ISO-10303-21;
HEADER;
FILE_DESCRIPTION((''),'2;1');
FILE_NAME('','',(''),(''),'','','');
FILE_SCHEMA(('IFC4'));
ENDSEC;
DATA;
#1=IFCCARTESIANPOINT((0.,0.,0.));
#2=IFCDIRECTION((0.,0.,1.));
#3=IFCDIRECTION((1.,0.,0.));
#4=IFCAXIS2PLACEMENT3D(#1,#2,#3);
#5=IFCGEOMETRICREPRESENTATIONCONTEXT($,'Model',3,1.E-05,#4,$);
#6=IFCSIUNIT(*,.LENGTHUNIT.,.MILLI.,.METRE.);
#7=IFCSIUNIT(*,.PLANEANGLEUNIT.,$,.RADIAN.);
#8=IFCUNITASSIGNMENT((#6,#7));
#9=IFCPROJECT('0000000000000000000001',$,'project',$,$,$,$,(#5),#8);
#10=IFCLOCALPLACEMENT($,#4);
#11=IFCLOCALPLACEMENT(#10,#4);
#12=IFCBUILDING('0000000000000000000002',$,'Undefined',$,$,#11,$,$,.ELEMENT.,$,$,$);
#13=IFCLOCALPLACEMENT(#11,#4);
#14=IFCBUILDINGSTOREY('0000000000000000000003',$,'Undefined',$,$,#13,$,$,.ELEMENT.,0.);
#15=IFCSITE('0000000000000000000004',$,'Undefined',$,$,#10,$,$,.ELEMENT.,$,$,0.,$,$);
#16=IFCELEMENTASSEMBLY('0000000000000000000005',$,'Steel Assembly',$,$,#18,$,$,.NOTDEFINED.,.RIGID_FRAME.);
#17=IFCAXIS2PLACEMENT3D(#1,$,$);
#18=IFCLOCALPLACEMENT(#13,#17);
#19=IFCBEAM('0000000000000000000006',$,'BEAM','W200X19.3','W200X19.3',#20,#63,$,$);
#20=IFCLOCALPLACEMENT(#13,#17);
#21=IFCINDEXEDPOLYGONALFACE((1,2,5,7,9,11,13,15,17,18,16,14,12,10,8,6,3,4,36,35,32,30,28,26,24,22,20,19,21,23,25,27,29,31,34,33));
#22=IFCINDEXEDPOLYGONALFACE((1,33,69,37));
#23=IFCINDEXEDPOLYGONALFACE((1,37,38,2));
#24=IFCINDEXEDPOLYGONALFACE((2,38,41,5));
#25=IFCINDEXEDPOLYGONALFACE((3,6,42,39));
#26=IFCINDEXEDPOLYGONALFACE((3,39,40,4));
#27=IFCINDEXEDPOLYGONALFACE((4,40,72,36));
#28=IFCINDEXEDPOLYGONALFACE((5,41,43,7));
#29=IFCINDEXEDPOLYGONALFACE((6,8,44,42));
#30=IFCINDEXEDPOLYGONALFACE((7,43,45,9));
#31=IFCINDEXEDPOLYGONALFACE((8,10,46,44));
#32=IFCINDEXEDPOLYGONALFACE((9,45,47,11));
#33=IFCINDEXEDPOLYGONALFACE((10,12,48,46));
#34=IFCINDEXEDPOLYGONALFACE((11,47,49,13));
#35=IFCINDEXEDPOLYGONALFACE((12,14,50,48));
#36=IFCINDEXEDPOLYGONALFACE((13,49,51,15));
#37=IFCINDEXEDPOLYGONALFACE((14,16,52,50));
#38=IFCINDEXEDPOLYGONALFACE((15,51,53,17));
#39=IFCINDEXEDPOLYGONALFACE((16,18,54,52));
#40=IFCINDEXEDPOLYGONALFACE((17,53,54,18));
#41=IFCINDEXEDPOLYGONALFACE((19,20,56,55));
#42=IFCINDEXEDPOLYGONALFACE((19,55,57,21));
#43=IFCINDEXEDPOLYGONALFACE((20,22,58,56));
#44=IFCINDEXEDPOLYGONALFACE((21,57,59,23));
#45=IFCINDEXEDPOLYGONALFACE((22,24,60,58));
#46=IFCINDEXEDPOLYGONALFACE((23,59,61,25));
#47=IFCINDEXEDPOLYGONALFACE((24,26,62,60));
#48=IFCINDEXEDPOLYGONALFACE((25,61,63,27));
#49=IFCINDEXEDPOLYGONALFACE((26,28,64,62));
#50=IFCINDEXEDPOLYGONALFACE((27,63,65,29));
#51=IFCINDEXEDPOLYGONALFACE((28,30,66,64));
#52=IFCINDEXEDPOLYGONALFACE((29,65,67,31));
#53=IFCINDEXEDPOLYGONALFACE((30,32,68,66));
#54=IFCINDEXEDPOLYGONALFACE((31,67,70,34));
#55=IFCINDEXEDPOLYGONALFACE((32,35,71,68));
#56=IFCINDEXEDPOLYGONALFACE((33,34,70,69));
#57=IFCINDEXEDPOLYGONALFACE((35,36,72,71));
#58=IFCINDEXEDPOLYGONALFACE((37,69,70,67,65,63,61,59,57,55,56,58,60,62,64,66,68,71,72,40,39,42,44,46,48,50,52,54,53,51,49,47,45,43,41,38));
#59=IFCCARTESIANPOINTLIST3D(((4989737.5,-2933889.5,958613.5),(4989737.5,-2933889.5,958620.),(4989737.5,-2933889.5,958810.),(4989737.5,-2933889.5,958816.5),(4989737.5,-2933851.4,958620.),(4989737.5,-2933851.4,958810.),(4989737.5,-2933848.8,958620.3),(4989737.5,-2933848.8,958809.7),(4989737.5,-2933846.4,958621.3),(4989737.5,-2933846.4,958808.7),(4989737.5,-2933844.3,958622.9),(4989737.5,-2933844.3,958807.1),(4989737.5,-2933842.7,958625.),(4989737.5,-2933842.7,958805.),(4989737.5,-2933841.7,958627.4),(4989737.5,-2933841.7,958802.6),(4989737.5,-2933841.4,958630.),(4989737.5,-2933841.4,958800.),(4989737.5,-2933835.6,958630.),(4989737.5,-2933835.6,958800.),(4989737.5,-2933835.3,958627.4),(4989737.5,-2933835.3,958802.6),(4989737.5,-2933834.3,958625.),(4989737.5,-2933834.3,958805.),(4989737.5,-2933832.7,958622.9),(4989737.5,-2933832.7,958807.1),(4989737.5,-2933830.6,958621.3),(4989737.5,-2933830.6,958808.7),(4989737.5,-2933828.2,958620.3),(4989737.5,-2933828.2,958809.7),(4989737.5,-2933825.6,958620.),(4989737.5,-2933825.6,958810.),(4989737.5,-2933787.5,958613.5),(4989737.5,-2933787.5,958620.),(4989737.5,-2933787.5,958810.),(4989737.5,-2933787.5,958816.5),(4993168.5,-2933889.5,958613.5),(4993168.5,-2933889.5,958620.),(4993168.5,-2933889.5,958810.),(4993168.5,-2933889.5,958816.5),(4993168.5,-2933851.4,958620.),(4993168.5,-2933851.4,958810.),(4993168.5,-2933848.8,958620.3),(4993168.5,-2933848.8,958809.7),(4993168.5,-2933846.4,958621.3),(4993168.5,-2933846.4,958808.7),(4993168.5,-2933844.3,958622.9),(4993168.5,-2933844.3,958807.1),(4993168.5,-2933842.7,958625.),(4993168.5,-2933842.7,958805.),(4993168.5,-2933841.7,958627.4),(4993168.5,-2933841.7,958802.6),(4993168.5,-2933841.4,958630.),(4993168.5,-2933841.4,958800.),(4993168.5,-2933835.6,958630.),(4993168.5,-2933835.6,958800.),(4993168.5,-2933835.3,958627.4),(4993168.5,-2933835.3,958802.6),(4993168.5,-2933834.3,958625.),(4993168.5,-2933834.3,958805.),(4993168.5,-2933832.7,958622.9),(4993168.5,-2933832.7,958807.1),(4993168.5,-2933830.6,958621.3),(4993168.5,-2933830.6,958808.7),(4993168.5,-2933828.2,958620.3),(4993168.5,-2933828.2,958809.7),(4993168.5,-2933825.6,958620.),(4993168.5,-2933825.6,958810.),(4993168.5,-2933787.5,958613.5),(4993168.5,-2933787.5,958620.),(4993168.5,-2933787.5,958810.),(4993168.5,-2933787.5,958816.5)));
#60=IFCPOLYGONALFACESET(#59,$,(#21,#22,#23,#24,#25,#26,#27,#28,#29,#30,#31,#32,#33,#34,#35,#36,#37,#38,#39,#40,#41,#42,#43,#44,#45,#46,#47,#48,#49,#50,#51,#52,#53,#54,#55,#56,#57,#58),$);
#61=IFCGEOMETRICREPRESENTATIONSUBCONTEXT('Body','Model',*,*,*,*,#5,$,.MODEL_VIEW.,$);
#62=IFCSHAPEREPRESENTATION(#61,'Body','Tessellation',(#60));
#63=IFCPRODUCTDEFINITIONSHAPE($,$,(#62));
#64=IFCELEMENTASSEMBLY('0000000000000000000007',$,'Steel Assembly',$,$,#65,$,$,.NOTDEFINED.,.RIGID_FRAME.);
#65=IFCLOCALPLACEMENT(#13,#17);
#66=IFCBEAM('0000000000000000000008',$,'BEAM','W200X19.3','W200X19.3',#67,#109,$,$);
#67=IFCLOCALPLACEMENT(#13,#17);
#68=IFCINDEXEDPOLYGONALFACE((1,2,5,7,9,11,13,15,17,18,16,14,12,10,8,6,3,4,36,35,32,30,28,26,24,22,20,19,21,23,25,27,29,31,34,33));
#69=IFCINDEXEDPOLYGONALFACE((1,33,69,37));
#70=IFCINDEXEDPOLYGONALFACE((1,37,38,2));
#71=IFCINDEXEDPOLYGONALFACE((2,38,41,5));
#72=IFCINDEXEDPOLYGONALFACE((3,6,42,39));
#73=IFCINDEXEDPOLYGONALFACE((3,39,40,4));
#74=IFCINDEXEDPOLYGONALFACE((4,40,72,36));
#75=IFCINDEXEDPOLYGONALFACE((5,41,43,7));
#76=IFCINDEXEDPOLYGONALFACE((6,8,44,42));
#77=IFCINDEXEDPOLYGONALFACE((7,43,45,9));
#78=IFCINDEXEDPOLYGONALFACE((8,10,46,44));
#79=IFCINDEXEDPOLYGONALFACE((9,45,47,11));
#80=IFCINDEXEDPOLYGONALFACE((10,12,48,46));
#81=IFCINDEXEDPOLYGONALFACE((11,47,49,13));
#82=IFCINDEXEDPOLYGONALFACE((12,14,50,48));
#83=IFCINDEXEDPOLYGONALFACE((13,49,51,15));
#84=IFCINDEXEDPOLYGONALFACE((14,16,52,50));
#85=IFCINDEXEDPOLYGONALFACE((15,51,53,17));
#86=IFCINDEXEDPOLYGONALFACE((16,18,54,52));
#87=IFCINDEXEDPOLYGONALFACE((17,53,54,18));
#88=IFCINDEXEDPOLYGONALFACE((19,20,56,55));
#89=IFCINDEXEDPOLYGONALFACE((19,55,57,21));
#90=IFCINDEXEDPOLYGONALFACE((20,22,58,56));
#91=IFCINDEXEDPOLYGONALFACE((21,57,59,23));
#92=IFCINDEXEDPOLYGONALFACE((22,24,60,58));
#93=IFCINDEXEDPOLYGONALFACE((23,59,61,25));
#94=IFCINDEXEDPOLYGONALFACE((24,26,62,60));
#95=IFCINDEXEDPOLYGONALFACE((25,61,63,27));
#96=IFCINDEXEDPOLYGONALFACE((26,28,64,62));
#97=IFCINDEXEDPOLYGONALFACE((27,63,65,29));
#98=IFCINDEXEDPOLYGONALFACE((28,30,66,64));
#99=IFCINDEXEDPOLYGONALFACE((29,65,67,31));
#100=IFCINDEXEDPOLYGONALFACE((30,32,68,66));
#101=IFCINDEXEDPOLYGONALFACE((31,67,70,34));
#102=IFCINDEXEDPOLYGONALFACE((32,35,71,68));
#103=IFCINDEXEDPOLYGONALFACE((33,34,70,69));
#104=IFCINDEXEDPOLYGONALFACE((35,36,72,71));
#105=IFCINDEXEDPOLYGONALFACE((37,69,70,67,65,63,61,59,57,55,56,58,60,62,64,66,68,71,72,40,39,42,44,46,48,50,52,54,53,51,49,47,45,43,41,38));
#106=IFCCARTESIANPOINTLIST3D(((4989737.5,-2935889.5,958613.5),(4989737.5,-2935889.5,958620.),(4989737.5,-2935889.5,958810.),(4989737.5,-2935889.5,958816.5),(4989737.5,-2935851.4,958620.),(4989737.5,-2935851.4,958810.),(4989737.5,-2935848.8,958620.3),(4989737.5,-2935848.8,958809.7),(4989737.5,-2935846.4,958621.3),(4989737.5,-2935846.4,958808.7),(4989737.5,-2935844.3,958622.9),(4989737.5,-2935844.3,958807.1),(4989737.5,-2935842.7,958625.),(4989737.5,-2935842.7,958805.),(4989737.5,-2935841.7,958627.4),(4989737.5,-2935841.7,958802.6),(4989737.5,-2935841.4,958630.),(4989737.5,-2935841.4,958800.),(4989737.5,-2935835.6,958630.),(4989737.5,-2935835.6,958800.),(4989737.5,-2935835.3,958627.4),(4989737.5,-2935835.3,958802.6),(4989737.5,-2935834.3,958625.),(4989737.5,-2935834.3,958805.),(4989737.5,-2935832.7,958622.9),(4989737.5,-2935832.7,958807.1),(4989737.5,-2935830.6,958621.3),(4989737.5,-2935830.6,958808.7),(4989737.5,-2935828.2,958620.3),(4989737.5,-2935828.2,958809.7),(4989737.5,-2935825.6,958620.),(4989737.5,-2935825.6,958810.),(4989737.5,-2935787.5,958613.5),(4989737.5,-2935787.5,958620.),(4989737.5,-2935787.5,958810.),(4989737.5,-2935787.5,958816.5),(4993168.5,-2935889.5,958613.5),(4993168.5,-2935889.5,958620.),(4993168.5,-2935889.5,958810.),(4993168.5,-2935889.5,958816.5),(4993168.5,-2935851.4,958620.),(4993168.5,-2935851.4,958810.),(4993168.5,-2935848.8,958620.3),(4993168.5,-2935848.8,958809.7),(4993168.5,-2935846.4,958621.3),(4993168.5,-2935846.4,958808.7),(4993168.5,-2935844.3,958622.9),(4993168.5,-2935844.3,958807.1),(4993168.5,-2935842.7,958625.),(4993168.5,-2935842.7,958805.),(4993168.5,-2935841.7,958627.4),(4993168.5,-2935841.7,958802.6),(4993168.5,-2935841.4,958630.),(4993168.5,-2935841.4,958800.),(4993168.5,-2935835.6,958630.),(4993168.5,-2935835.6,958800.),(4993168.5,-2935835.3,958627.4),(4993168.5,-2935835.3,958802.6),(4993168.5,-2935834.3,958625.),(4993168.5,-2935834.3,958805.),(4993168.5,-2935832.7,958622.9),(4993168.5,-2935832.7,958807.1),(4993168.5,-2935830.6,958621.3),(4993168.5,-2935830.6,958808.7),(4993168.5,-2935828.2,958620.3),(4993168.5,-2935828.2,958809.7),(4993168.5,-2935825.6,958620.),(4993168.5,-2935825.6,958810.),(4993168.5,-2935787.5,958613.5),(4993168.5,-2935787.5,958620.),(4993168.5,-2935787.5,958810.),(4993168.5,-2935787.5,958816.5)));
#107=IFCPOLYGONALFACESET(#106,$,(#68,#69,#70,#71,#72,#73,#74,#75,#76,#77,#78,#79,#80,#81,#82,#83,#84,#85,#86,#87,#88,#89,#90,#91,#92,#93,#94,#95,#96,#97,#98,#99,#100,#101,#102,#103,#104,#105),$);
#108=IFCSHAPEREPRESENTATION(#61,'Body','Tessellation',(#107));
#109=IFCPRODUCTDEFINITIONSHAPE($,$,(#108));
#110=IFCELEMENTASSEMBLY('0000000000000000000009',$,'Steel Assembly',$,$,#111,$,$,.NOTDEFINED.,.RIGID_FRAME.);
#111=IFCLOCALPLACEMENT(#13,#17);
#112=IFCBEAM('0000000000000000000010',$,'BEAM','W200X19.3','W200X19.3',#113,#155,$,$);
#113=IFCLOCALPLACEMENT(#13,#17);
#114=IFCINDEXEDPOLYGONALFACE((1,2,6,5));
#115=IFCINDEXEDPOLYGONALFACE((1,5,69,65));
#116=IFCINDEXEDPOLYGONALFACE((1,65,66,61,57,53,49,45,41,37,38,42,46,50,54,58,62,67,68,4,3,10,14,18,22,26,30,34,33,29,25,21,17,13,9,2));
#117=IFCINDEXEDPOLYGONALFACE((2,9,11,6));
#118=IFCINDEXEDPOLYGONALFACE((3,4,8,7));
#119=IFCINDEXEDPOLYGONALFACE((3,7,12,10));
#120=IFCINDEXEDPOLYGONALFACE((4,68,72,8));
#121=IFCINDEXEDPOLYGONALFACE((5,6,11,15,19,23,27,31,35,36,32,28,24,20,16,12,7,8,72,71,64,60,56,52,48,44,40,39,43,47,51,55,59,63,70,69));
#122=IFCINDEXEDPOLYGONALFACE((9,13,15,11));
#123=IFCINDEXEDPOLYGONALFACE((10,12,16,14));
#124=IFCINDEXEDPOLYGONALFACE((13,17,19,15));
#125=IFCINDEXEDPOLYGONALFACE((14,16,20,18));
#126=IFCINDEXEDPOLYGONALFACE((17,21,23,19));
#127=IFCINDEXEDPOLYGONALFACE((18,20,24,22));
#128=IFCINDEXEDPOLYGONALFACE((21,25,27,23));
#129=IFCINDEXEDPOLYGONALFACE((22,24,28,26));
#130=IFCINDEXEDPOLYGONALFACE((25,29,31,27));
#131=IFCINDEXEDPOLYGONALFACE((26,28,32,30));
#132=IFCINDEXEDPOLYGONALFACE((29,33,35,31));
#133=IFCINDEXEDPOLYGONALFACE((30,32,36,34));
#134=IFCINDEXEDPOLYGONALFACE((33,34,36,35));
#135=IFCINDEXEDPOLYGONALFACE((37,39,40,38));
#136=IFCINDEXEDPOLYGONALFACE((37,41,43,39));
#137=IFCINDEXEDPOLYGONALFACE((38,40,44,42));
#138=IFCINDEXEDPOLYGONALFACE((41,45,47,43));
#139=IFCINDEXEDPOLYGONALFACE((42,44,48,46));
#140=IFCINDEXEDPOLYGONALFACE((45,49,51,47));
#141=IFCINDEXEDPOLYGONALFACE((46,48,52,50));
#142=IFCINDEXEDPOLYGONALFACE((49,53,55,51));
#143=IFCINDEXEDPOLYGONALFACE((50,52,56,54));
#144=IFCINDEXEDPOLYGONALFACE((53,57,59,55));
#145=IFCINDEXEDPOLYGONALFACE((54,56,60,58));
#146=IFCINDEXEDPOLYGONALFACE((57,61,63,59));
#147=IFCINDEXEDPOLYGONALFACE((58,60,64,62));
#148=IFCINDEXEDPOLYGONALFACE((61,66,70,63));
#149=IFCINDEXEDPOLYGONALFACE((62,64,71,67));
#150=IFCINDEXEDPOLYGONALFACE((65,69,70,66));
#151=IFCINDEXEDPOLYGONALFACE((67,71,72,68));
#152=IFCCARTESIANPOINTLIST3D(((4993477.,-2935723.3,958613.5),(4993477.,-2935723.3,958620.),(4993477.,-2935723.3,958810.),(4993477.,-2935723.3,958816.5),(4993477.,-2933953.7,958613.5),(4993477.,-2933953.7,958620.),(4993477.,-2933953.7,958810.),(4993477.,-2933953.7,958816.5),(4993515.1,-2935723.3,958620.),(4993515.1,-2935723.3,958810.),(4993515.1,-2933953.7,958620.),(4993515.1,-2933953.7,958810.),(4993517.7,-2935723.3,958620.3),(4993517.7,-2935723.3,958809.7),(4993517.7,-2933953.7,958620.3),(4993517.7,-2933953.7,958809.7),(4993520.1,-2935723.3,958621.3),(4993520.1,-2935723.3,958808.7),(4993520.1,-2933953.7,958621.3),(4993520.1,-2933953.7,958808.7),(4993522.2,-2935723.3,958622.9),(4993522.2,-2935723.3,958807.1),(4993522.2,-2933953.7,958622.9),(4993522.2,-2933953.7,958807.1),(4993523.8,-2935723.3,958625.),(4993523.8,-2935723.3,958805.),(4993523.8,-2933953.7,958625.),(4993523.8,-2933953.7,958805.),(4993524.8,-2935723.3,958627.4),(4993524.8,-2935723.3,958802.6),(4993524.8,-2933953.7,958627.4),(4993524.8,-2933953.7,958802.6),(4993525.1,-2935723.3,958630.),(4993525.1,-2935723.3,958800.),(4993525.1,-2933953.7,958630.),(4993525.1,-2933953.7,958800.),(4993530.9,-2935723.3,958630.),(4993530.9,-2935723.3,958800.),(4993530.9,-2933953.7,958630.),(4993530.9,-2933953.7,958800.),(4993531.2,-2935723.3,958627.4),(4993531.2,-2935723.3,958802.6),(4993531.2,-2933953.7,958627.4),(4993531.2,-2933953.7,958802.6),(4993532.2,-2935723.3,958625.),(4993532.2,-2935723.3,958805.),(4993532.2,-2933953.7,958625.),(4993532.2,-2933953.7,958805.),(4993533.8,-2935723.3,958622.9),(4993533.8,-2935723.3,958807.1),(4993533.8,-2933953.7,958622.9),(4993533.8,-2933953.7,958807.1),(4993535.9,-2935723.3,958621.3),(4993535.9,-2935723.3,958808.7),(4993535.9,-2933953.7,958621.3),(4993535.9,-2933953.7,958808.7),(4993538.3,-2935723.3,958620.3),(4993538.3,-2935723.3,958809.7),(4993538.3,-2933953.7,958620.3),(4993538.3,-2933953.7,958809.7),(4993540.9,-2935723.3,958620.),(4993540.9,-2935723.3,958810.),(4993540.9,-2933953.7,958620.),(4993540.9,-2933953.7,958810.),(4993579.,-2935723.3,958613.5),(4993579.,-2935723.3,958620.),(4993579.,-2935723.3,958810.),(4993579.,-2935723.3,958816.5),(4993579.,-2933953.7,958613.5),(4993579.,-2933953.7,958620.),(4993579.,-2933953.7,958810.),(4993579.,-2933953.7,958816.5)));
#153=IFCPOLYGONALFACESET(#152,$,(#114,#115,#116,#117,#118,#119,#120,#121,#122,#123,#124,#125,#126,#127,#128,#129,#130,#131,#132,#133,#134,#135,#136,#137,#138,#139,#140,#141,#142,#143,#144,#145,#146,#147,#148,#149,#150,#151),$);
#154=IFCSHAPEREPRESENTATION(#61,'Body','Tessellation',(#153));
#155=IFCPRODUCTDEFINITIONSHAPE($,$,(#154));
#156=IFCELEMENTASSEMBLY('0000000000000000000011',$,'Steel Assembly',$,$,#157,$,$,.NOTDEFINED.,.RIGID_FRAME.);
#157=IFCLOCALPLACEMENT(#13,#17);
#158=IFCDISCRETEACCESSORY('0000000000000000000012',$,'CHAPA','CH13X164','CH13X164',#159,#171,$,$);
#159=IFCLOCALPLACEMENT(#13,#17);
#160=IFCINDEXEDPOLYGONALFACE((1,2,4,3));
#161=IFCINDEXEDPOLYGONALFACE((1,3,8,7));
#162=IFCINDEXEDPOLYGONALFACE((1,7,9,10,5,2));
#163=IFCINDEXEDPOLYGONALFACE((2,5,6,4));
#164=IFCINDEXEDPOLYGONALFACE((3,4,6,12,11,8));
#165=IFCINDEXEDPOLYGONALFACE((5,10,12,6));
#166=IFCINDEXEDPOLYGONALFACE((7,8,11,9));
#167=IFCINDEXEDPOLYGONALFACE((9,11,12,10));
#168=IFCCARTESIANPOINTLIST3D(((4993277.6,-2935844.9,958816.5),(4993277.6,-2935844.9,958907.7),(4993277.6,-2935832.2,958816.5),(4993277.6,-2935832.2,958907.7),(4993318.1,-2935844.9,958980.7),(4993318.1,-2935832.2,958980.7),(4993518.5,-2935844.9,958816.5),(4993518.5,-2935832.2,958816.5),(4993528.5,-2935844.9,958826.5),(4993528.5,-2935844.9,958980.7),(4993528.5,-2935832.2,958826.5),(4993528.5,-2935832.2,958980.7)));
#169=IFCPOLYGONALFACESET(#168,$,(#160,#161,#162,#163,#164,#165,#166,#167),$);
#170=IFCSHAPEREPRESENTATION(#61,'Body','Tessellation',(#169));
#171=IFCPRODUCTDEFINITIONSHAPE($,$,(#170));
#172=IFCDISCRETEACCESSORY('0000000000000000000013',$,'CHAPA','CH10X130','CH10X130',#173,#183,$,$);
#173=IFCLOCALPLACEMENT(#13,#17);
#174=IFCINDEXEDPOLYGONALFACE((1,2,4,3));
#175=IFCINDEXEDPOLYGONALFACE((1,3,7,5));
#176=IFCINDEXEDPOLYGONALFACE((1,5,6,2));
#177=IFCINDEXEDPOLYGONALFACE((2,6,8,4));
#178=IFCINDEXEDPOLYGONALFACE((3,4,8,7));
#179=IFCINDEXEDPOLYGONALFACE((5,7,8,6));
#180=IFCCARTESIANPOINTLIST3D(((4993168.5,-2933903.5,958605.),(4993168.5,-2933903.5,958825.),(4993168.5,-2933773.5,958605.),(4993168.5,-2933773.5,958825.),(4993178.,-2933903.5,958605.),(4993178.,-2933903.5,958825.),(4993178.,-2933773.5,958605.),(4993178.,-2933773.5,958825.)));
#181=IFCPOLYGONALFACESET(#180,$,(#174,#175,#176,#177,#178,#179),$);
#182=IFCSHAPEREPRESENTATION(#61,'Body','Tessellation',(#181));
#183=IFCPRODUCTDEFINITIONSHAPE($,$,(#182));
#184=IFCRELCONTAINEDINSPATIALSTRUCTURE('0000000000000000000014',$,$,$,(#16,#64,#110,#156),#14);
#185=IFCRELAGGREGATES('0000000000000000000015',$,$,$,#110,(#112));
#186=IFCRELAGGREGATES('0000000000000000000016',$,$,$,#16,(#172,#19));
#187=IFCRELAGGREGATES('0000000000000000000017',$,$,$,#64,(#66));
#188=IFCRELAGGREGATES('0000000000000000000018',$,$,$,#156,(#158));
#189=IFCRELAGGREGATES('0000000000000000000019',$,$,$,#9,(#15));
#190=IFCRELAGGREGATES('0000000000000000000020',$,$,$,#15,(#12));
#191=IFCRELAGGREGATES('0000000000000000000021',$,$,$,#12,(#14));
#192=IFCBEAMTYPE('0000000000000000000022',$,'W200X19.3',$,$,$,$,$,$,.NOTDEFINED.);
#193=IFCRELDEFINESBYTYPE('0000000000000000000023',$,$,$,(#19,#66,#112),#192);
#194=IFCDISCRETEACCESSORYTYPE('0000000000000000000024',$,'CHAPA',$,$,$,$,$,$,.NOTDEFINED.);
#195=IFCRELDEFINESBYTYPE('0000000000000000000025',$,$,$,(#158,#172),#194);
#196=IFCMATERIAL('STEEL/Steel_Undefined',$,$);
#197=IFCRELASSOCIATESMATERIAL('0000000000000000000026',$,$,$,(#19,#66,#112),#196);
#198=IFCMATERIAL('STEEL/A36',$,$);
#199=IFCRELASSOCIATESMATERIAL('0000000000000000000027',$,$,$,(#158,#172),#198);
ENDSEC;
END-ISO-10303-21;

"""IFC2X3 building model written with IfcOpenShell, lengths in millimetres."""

from ifc_helpers import new_model, si_unit, frame, origin_with_axes, origin_2d_with_axis, place, context, subcontext, project, spatial, polyline, i_section, outline, extrude, clip, halfspace, material, type_object, element, aggregate, save


model = new_model("IFC2X3")

# Units and contexts
model_context = context("Model", 3, precision=1e-05, world=origin_with_axes())
body_context = subcontext(model_context, "Body", "Model", "MODEL_VIEW")
ifc_project = project(units=[si_unit("LENGTHUNIT", "METRE", prefix="MILLI"), si_unit("PLANEANGLEUNIT", "RADIAN")], contexts=[model_context])

# Site, building, storey
site_placement = place(None, origin_with_axes())
site = spatial("IfcSite", under=ifc_project, at=site_placement, Name="Undefined", CompositionType="ELEMENT", RefElevation=0.0)
building_placement = place(site_placement, origin_with_axes())
building = spatial("IfcBuilding", under=site, at=building_placement, Name="Undefined", CompositionType="ELEMENT")
storey_placement = place(building_placement, origin_with_axes())
storey = spatial("IfcBuildingStorey", under=building, at=storey_placement, Name="Undefined", CompositionType="ELEMENT", Elevation=0.0)

# Element assemblies, beams
assembly_1_placement = place(storey_placement, origin_with_axes())
assembly_1 = element("IfcElementAssembly", 1, at=assembly_1_placement, inside=storey, Name="Steel Assembly", AssemblyPlace="NOTDEFINED", PredefinedType="RIGID_FRAME")
ifc_material_1 = material(Name="STEEL/Steel_Undefined")
beam_type = type_object("IfcBeamType", Name="W200X19.3", PredefinedType="NOTDEFINED")
beam_1_placement = place(assembly_1_placement, frame((4993179.0, -2933838.5, 958715.0), z_axis=(0.0, 0.0, -1.0), x_axis=(-1.0, 0.0, 0.0)))
beam_1 = element("IfcBeam", 2, at=beam_1_placement, type_object=beam_type, material=ifc_material_1, Name="BEAM", Description="W200X19.3", ObjectType="W200X19.3", context=body_context, shape_type="Clipping", body=[
    clip(clip(extrude(i_section(OverallWidth=102.0, OverallDepth=203.0, WebThickness=5.8, FlangeThickness=6.5, FilletRadius=10.0, at=origin_2d_with_axis()), frame((3441.5, 0.0, 0.0), z_axis=(-1.0, 0.0, 0.0), x_axis=(0.0, -1.0, 0.0)), (0.0, 0.0, 1.0), 3431.0), halfspace(frame((3441.5, 0.0, -101.5), z_axis=(-1.0, 0.0, 0.0), x_axis=(0.0, 1.0, 0.0)), True)), halfspace(frame((10.5, 0.0, -101.5), z_axis=(1.0, 0.0, 0.0), x_axis=(0.0, -1.0, 0.0)), True)),
])
assembly_2_placement = place(storey_placement, origin_with_axes())
assembly_2 = element("IfcElementAssembly", 3, at=assembly_2_placement, inside=storey, Name="Steel Assembly", AssemblyPlace="NOTDEFINED", PredefinedType="RIGID_FRAME")
beam_2_placement = place(assembly_2_placement, frame((4993179.0, -2935838.5, 958715.0), z_axis=(0.0, 0.0, -1.0), x_axis=(-1.0, 0.0, 0.0)))
beam_2 = element("IfcBeam", 4, at=beam_2_placement, type_object=beam_type, material=ifc_material_1, Name="BEAM", Description="W200X19.3", ObjectType="W200X19.3", context=body_context, shape_type="Clipping", body=[
    clip(clip(extrude(i_section(OverallWidth=102.0, OverallDepth=203.0, WebThickness=5.8, FlangeThickness=6.5, FilletRadius=10.0, at=origin_2d_with_axis()), frame((3441.5, 0.0, 0.0), z_axis=(-1.0, 0.0, 0.0), x_axis=(0.0, -1.0, 0.0)), (0.0, 0.0, 1.0), 3431.0), halfspace(frame((3441.5, 0.0, -101.5), z_axis=(-1.0, 0.0, 0.0), x_axis=(0.0, 1.0, 0.0)), True)), halfspace(frame((10.5, 0.0, -101.5), z_axis=(1.0, 0.0, 0.0), x_axis=(0.0, -1.0, 0.0)), True)),
])
assembly_3_placement = place(storey_placement, origin_with_axes())
assembly_3 = element("IfcElementAssembly", 5, at=assembly_3_placement, inside=storey, Name="Steel Assembly", AssemblyPlace="NOTDEFINED", PredefinedType="RIGID_FRAME")
beam_3_placement = place(assembly_3_placement, frame((4993528.0, -2933838.5, 958715.0), z_axis=(0.0, 0.0, -1.0), x_axis=(0.0, -1.0, 0.0)))
beam_3 = element("IfcBeam", 6, at=beam_3_placement, type_object=beam_type, material=ifc_material_1, Name="BEAM", Description="W200X19.3", ObjectType="W200X19.3", context=body_context, shape_type="Clipping", body=[
    clip(clip(clip(clip(extrude(i_section(OverallWidth=102.0, OverallDepth=203.0, WebThickness=5.8, FlangeThickness=6.5, FilletRadius=10.0, at=origin_2d_with_axis()), frame((1884.8, 0.0, 0.0), z_axis=(-1.0, 0.0, 0.0), x_axis=(0.0, -1.0, 0.0)), (0.0, 0.0, 1.0), 1769.6), halfspace(frame((1886.8, 51.0, 103.0), z_axis=(1.0, 0.0, 0.0), x_axis=(0.0, 0.0, -1.0)), False)), halfspace(frame((113.2, -51.0, 100.0), z_axis=(-1.0, 0.0, 0.0), x_axis=(0.0, 0.0, -1.0)), False)), halfspace(frame((1884.8, 0.0, 101.5), z_axis=(-1.0, 0.0, 0.0), x_axis=(0.0, -1.0, 0.0)), True)), halfspace(frame((115.2, 0.0, 101.5), z_axis=(1.0, 0.0, 0.0), x_axis=(0.0, 1.0, 0.0)), True)),
])
aggregate(assembly_3, [beam_3])

# Element assembly, discrete accessory
assembly_4_placement = place(storey_placement, origin_with_axes())
assembly_4 = element("IfcElementAssembly", 7, at=assembly_4_placement, inside=storey, Name="Steel Assembly", AssemblyPlace="NOTDEFINED", PredefinedType="RIGID_FRAME")
ifc_material_2 = material(Name="STEEL/A36")
discrete_accessory_type_1 = type_object("IfcDiscreteAccessoryType", Name="CHAPA")
discrete_accessory_1_placement = place(assembly_4_placement, frame((4993528.5, -2935838.5, 958816.5), z_axis=(0.0, 1.0, 0.0), x_axis=(-1.0, 0.0, 0.0)))
discrete_accessory_1 = element("IfcDiscreteAccessory", 8, at=discrete_accessory_1_placement, type_object=discrete_accessory_type_1, material=ifc_material_2, Name="CHAPA", Description="CH13X164", ObjectType="CH13X164", context=body_context, shape_type="SweptSolid", body=[
    extrude(outline(polyline([(0.0, 10.0), (10.0, 0.0), (250.9, 0.0), (250.9, 91.2), (210.4, 164.2), (0.0, 164.2), (0.0, 10.0)])), frame((0.0, 0.0, -6.3), z_axis=(0.0, 0.0, 1.0), x_axis=(1.0, 0.0, 0.0)), (0.0, 0.0, 1.0), 12.7),
])

# Discrete accessory
discrete_accessory_2_placement = place(assembly_1_placement, frame((4993173.2, -2933838.5, 958825.0), z_axis=(-1.0, 0.0, 0.0), x_axis=(0.0, 0.0, -1.0)))
discrete_accessory_2 = element("IfcDiscreteAccessory", 9, at=discrete_accessory_2_placement, type_object=discrete_accessory_type_1, material=ifc_material_2, Name="CHAPA", Description="CH10X130", ObjectType="CH10X130", context=body_context, shape_type="SweptSolid", body=[
    extrude(outline(polyline([(220.0, 65.0), (220.0, -65.0), (0.0, -65.0), (0.0, 65.0), (220.0, 65.0)])), frame((0.0, 0.0, -4.8), z_axis=(0.0, 0.0, 1.0), x_axis=(1.0, 0.0, 0.0)), (0.0, 0.0, 1.0), 9.5),
])
aggregate(assembly_1, [discrete_accessory_2, beam_1])

aggregate(assembly_2, [beam_2])

aggregate(assembly_4, [discrete_accessory_1])

save(model, "model.ifc")
